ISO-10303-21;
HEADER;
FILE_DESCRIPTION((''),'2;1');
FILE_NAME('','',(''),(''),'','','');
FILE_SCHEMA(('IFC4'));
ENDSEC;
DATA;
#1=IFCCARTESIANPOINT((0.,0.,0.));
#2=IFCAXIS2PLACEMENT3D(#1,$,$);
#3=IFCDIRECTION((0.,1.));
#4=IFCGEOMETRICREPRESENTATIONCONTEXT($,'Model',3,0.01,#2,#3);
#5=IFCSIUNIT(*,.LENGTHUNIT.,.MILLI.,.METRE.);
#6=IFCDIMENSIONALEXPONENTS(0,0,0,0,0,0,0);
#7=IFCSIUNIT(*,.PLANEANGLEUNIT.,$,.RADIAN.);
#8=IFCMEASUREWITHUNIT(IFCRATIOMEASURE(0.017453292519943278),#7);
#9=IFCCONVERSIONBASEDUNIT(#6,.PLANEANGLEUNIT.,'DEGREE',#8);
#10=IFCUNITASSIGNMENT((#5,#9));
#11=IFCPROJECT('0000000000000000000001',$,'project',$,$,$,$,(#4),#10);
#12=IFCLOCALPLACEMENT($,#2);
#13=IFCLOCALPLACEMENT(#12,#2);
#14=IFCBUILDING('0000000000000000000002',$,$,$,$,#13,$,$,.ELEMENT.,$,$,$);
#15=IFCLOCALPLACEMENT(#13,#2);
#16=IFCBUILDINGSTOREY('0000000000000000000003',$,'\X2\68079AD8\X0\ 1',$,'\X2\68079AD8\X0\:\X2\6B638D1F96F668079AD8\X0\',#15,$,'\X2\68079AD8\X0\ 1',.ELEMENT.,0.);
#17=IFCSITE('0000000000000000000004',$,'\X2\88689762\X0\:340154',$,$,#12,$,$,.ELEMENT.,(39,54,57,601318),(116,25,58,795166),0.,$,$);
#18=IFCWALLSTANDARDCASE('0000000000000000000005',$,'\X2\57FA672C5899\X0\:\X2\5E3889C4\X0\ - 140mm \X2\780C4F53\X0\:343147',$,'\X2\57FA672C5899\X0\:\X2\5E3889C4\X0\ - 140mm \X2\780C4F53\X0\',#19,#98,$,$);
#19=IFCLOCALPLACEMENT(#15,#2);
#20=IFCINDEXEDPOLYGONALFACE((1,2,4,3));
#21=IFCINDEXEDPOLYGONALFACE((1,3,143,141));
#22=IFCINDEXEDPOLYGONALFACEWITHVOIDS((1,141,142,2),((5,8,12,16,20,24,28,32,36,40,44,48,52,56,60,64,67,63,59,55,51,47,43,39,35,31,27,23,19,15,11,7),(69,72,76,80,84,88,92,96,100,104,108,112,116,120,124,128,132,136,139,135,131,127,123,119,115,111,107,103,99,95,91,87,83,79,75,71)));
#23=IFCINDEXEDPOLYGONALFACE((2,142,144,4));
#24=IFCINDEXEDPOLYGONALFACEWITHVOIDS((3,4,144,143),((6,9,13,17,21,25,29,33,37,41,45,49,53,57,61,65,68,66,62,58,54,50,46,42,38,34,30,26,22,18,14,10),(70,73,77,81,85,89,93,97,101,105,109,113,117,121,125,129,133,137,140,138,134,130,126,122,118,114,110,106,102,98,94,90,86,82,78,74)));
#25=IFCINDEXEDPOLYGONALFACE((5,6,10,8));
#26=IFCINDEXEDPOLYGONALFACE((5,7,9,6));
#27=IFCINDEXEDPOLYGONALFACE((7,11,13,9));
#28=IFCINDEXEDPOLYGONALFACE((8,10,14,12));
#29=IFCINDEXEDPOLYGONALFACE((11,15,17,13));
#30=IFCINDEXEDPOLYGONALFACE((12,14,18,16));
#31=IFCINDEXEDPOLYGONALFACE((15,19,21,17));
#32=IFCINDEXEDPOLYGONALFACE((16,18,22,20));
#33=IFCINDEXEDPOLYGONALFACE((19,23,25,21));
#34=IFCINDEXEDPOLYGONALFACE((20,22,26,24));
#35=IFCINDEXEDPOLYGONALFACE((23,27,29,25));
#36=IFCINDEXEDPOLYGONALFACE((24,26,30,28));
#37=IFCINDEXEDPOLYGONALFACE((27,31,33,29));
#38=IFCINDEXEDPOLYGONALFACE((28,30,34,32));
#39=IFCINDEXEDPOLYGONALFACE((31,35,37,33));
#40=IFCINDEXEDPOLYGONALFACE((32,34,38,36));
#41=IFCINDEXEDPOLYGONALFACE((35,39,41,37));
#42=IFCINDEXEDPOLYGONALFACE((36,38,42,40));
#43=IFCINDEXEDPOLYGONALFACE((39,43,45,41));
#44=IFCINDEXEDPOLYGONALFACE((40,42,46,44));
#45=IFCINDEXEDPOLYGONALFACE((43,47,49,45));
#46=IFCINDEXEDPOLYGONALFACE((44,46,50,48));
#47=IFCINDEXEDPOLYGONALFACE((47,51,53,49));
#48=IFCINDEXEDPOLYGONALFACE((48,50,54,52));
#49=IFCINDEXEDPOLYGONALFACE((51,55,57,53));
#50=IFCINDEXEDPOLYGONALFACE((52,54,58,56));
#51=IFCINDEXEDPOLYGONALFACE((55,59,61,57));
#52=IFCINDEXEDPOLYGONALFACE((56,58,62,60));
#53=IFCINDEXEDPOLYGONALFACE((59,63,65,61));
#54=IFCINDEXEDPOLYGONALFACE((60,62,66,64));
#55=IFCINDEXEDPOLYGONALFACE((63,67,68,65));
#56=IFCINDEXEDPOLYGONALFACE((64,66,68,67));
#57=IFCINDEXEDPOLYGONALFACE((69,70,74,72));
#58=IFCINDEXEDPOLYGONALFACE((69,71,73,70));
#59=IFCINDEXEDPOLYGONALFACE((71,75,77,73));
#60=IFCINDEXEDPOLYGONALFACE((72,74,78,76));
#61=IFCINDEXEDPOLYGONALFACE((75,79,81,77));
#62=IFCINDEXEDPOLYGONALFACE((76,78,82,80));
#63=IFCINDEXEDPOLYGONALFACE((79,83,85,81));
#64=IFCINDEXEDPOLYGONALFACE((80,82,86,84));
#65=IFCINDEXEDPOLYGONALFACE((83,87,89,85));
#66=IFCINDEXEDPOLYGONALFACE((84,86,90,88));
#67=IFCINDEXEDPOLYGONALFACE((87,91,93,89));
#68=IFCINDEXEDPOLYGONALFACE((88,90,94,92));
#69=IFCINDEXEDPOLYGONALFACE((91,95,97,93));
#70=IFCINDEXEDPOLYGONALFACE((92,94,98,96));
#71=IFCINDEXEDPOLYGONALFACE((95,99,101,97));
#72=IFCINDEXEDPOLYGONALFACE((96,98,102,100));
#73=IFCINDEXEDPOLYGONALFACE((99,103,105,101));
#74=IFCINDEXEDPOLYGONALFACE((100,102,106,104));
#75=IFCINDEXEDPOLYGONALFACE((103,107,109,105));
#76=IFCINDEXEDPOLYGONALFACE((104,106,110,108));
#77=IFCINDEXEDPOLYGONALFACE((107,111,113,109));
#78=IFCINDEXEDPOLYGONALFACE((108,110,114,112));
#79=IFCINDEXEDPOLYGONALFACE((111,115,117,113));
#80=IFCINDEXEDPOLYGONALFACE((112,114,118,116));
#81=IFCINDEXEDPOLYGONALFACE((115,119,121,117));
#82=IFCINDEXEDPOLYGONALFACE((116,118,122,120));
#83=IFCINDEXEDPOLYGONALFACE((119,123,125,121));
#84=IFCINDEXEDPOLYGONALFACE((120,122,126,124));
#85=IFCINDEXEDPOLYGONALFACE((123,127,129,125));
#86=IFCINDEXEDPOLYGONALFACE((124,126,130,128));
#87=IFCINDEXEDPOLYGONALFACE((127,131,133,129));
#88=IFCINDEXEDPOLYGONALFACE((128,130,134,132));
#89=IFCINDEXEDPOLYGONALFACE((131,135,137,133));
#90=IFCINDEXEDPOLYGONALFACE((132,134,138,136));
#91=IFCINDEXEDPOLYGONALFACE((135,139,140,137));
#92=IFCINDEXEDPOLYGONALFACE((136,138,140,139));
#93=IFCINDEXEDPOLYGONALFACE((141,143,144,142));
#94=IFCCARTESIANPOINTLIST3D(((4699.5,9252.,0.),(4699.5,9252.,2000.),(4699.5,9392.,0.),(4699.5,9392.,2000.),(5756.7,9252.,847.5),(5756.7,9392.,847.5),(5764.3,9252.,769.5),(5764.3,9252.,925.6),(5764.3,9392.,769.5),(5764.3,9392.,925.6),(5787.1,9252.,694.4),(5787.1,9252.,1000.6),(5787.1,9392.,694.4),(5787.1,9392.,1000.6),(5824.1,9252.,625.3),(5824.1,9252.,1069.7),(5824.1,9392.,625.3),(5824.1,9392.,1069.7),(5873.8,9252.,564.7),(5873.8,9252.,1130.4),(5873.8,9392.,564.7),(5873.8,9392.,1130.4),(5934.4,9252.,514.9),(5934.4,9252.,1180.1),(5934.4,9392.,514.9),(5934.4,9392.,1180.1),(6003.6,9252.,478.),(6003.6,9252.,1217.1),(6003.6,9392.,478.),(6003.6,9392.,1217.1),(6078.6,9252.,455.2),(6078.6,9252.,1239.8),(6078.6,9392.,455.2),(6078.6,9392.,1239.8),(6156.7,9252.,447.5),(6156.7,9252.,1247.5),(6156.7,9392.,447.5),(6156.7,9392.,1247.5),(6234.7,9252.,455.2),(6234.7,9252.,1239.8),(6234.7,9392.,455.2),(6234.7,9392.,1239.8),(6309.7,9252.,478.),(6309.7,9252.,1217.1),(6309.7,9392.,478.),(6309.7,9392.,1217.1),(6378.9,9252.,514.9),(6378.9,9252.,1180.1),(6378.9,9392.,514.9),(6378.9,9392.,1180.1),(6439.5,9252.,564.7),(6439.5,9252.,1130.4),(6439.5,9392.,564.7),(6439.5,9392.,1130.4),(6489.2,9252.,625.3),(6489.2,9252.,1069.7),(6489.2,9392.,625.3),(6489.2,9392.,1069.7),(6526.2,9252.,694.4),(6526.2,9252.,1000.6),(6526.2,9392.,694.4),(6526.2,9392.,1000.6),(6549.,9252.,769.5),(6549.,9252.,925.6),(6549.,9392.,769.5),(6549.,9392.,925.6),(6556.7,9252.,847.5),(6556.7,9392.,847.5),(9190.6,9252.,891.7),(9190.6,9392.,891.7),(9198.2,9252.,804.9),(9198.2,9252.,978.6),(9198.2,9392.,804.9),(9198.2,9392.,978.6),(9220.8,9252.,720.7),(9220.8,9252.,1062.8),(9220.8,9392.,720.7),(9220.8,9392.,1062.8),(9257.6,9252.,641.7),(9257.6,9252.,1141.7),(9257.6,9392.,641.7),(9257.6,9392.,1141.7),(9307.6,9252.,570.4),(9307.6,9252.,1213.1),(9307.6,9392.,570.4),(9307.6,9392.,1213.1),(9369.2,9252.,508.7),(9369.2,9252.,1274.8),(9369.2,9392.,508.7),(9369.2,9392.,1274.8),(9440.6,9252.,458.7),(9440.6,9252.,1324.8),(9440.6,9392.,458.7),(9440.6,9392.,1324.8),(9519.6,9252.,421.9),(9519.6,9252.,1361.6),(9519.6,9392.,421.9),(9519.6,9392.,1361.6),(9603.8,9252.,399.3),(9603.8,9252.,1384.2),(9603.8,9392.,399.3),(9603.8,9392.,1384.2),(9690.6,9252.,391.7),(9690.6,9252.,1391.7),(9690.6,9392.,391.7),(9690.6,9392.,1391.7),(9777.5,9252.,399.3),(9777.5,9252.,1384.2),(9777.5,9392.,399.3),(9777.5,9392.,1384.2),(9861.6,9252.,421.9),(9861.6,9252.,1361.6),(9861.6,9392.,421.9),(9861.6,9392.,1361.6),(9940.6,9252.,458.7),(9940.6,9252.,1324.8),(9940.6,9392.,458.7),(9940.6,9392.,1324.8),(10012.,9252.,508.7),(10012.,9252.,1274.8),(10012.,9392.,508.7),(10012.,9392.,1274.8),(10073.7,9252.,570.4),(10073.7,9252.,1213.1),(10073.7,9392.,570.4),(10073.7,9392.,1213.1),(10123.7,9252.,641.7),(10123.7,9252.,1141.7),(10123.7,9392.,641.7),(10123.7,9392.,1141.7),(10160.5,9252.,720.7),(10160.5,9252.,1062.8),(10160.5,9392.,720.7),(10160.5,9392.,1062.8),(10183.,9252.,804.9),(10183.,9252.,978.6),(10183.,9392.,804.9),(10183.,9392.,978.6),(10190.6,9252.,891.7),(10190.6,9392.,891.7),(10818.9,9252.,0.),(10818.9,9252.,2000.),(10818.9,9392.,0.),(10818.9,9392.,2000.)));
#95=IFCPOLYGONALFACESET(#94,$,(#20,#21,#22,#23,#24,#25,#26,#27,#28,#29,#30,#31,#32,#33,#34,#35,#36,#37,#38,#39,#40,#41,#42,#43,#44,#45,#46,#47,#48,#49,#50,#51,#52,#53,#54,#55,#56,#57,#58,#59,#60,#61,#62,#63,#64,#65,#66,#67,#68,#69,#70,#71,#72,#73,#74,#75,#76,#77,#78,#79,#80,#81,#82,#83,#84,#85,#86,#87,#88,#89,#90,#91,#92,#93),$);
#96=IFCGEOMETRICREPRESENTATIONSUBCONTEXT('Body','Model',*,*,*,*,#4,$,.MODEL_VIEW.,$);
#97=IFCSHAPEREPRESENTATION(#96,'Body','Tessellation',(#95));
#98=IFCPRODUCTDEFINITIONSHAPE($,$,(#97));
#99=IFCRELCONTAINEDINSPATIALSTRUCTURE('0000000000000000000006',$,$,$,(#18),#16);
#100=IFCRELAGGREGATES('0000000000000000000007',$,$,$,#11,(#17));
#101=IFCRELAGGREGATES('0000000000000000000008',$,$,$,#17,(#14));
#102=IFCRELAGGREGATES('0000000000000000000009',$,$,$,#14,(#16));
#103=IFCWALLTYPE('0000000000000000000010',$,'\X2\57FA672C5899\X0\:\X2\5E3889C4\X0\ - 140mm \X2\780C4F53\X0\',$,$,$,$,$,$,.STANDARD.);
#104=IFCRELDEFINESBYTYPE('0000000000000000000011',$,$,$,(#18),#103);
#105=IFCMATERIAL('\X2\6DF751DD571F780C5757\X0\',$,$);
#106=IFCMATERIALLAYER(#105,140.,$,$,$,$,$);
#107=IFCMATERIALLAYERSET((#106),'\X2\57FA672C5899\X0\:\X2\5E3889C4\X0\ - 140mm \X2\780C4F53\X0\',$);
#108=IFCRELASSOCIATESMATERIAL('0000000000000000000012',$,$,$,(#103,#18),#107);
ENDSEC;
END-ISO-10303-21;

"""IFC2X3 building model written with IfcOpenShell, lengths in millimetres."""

from ifc_helpers import new_model, entity, si_unit, converted_unit, direction, frame, frame_2d, origin, place, context, subcontext, project, spatial, rectangle, circle, extrude, material, layer, layer_set, layer_usage, type_object, element, save


model = new_model("IFC2X3")

# Units and contexts
model_context = context("Model", 3, precision=0.01, world=origin(), true_north=direction((0.0, 1.0)))
body_context = subcontext(model_context, "Body", "Model", "MODEL_VIEW")
ifc_project = project(units=[si_unit("LENGTHUNIT", "METRE", prefix="MILLI"), converted_unit("PLANEANGLEUNIT", "DEGREE", entity("IfcRatioMeasure", 0.017453292519943278), si_unit("PLANEANGLEUNIT", "RADIAN"), dimensions=[0, 0, 0, 0, 0, 0, 0])], contexts=[model_context])

# Site, building, storey
site_placement = place(None, origin())
site = spatial("IfcSite", under=ifc_project, at=site_placement, Name="表面:340154", CompositionType="ELEMENT", RefLatitude=(39, 54, 57, 601318), RefLongitude=(116, 25, 58, 795166), RefElevation=0.0)
building_placement = place(site_placement, origin())
building = spatial("IfcBuilding", under=site, at=building_placement, CompositionType="ELEMENT")
storey_placement = place(building_placement, origin())
storey = spatial("IfcBuildingStorey", under=building, at=storey_placement, Name="标高 1", ObjectType="标高:正负零标高", LongName="标高 1", CompositionType="ELEMENT", Elevation=0.0)

# Shared definitions
ifc_material_1 = material(Name="混凝土砌块")
ifc_layer_1 = layer(ifc_material_1, 140.0)
ifc_layer_set_1 = layer_set([ifc_layer_1], Name="基本墙:常规 - 140mm 砌体")
wall_type_1 = type_object("IfcWallType", Name="基本墙:常规 - 140mm 砌体", PredefinedType="STANDARD", material=ifc_layer_set_1)

# Wall, openings
ifc_layer_usage_1 = layer_usage(ifc_layer_set_1, "AXIS2", "NEGATIVE", 70.0)
wall_1_placement = place(storey_placement, frame((10818.9, 9322.0, 0.0), z_axis=(0.0, 0.0, 1.0), x_axis=(-1.0, 0.0, 0.0)))
wall_1 = element("IfcWallStandardCase", 1, at=wall_1_placement, inside=storey, type_object=wall_type_1, material=ifc_layer_usage_1, Name="基本墙:常规 - 140mm 砌体:343147", ObjectType="基本墙:常规 - 140mm 砌体", context=body_context, shape_type="SweptSolid", body=[
    extrude(rectangle(XDim=6119.5, YDim=140.0, at=frame_2d((3059.7, 0.0), x_axis=(-1.0, 0.0))), origin(), (0.0, 0.0, 1.0), 2000.0),
])
opening_1_placement = place(wall_1_placement, origin())
element("IfcOpeningElement", 2, at=opening_1_placement, cuts=wall_1, ObjectType="Opening", context=body_context, shape_type="SweptSolid", body=[
    extrude(circle(Radius=400.0, at=frame_2d((0.0, 0.0), x_axis=(1.0, 0.0))), frame((4662.3, 70.0, 847.5), z_axis=(0.0, -1.0, 0.0), x_axis=(-1.0, 0.0, 0.0)), (0.0, 0.0, 1.0), 140.0),
])
opening_2_placement = place(wall_1_placement, origin())
element("IfcOpeningElement", 3, at=opening_2_placement, cuts=wall_1, ObjectType="Opening", context=body_context, shape_type="SweptSolid", body=[
    extrude(circle(Radius=500.0, at=frame_2d((0.0, 0.0), x_axis=(1.0, 0.0))), frame((1128.3, 70.0, 891.7), z_axis=(0.0, -1.0, 0.0), x_axis=(-1.0, 0.0, 0.0)), (0.0, 0.0, 1.0), 140.0),
])

save(model, "model.ifc")
